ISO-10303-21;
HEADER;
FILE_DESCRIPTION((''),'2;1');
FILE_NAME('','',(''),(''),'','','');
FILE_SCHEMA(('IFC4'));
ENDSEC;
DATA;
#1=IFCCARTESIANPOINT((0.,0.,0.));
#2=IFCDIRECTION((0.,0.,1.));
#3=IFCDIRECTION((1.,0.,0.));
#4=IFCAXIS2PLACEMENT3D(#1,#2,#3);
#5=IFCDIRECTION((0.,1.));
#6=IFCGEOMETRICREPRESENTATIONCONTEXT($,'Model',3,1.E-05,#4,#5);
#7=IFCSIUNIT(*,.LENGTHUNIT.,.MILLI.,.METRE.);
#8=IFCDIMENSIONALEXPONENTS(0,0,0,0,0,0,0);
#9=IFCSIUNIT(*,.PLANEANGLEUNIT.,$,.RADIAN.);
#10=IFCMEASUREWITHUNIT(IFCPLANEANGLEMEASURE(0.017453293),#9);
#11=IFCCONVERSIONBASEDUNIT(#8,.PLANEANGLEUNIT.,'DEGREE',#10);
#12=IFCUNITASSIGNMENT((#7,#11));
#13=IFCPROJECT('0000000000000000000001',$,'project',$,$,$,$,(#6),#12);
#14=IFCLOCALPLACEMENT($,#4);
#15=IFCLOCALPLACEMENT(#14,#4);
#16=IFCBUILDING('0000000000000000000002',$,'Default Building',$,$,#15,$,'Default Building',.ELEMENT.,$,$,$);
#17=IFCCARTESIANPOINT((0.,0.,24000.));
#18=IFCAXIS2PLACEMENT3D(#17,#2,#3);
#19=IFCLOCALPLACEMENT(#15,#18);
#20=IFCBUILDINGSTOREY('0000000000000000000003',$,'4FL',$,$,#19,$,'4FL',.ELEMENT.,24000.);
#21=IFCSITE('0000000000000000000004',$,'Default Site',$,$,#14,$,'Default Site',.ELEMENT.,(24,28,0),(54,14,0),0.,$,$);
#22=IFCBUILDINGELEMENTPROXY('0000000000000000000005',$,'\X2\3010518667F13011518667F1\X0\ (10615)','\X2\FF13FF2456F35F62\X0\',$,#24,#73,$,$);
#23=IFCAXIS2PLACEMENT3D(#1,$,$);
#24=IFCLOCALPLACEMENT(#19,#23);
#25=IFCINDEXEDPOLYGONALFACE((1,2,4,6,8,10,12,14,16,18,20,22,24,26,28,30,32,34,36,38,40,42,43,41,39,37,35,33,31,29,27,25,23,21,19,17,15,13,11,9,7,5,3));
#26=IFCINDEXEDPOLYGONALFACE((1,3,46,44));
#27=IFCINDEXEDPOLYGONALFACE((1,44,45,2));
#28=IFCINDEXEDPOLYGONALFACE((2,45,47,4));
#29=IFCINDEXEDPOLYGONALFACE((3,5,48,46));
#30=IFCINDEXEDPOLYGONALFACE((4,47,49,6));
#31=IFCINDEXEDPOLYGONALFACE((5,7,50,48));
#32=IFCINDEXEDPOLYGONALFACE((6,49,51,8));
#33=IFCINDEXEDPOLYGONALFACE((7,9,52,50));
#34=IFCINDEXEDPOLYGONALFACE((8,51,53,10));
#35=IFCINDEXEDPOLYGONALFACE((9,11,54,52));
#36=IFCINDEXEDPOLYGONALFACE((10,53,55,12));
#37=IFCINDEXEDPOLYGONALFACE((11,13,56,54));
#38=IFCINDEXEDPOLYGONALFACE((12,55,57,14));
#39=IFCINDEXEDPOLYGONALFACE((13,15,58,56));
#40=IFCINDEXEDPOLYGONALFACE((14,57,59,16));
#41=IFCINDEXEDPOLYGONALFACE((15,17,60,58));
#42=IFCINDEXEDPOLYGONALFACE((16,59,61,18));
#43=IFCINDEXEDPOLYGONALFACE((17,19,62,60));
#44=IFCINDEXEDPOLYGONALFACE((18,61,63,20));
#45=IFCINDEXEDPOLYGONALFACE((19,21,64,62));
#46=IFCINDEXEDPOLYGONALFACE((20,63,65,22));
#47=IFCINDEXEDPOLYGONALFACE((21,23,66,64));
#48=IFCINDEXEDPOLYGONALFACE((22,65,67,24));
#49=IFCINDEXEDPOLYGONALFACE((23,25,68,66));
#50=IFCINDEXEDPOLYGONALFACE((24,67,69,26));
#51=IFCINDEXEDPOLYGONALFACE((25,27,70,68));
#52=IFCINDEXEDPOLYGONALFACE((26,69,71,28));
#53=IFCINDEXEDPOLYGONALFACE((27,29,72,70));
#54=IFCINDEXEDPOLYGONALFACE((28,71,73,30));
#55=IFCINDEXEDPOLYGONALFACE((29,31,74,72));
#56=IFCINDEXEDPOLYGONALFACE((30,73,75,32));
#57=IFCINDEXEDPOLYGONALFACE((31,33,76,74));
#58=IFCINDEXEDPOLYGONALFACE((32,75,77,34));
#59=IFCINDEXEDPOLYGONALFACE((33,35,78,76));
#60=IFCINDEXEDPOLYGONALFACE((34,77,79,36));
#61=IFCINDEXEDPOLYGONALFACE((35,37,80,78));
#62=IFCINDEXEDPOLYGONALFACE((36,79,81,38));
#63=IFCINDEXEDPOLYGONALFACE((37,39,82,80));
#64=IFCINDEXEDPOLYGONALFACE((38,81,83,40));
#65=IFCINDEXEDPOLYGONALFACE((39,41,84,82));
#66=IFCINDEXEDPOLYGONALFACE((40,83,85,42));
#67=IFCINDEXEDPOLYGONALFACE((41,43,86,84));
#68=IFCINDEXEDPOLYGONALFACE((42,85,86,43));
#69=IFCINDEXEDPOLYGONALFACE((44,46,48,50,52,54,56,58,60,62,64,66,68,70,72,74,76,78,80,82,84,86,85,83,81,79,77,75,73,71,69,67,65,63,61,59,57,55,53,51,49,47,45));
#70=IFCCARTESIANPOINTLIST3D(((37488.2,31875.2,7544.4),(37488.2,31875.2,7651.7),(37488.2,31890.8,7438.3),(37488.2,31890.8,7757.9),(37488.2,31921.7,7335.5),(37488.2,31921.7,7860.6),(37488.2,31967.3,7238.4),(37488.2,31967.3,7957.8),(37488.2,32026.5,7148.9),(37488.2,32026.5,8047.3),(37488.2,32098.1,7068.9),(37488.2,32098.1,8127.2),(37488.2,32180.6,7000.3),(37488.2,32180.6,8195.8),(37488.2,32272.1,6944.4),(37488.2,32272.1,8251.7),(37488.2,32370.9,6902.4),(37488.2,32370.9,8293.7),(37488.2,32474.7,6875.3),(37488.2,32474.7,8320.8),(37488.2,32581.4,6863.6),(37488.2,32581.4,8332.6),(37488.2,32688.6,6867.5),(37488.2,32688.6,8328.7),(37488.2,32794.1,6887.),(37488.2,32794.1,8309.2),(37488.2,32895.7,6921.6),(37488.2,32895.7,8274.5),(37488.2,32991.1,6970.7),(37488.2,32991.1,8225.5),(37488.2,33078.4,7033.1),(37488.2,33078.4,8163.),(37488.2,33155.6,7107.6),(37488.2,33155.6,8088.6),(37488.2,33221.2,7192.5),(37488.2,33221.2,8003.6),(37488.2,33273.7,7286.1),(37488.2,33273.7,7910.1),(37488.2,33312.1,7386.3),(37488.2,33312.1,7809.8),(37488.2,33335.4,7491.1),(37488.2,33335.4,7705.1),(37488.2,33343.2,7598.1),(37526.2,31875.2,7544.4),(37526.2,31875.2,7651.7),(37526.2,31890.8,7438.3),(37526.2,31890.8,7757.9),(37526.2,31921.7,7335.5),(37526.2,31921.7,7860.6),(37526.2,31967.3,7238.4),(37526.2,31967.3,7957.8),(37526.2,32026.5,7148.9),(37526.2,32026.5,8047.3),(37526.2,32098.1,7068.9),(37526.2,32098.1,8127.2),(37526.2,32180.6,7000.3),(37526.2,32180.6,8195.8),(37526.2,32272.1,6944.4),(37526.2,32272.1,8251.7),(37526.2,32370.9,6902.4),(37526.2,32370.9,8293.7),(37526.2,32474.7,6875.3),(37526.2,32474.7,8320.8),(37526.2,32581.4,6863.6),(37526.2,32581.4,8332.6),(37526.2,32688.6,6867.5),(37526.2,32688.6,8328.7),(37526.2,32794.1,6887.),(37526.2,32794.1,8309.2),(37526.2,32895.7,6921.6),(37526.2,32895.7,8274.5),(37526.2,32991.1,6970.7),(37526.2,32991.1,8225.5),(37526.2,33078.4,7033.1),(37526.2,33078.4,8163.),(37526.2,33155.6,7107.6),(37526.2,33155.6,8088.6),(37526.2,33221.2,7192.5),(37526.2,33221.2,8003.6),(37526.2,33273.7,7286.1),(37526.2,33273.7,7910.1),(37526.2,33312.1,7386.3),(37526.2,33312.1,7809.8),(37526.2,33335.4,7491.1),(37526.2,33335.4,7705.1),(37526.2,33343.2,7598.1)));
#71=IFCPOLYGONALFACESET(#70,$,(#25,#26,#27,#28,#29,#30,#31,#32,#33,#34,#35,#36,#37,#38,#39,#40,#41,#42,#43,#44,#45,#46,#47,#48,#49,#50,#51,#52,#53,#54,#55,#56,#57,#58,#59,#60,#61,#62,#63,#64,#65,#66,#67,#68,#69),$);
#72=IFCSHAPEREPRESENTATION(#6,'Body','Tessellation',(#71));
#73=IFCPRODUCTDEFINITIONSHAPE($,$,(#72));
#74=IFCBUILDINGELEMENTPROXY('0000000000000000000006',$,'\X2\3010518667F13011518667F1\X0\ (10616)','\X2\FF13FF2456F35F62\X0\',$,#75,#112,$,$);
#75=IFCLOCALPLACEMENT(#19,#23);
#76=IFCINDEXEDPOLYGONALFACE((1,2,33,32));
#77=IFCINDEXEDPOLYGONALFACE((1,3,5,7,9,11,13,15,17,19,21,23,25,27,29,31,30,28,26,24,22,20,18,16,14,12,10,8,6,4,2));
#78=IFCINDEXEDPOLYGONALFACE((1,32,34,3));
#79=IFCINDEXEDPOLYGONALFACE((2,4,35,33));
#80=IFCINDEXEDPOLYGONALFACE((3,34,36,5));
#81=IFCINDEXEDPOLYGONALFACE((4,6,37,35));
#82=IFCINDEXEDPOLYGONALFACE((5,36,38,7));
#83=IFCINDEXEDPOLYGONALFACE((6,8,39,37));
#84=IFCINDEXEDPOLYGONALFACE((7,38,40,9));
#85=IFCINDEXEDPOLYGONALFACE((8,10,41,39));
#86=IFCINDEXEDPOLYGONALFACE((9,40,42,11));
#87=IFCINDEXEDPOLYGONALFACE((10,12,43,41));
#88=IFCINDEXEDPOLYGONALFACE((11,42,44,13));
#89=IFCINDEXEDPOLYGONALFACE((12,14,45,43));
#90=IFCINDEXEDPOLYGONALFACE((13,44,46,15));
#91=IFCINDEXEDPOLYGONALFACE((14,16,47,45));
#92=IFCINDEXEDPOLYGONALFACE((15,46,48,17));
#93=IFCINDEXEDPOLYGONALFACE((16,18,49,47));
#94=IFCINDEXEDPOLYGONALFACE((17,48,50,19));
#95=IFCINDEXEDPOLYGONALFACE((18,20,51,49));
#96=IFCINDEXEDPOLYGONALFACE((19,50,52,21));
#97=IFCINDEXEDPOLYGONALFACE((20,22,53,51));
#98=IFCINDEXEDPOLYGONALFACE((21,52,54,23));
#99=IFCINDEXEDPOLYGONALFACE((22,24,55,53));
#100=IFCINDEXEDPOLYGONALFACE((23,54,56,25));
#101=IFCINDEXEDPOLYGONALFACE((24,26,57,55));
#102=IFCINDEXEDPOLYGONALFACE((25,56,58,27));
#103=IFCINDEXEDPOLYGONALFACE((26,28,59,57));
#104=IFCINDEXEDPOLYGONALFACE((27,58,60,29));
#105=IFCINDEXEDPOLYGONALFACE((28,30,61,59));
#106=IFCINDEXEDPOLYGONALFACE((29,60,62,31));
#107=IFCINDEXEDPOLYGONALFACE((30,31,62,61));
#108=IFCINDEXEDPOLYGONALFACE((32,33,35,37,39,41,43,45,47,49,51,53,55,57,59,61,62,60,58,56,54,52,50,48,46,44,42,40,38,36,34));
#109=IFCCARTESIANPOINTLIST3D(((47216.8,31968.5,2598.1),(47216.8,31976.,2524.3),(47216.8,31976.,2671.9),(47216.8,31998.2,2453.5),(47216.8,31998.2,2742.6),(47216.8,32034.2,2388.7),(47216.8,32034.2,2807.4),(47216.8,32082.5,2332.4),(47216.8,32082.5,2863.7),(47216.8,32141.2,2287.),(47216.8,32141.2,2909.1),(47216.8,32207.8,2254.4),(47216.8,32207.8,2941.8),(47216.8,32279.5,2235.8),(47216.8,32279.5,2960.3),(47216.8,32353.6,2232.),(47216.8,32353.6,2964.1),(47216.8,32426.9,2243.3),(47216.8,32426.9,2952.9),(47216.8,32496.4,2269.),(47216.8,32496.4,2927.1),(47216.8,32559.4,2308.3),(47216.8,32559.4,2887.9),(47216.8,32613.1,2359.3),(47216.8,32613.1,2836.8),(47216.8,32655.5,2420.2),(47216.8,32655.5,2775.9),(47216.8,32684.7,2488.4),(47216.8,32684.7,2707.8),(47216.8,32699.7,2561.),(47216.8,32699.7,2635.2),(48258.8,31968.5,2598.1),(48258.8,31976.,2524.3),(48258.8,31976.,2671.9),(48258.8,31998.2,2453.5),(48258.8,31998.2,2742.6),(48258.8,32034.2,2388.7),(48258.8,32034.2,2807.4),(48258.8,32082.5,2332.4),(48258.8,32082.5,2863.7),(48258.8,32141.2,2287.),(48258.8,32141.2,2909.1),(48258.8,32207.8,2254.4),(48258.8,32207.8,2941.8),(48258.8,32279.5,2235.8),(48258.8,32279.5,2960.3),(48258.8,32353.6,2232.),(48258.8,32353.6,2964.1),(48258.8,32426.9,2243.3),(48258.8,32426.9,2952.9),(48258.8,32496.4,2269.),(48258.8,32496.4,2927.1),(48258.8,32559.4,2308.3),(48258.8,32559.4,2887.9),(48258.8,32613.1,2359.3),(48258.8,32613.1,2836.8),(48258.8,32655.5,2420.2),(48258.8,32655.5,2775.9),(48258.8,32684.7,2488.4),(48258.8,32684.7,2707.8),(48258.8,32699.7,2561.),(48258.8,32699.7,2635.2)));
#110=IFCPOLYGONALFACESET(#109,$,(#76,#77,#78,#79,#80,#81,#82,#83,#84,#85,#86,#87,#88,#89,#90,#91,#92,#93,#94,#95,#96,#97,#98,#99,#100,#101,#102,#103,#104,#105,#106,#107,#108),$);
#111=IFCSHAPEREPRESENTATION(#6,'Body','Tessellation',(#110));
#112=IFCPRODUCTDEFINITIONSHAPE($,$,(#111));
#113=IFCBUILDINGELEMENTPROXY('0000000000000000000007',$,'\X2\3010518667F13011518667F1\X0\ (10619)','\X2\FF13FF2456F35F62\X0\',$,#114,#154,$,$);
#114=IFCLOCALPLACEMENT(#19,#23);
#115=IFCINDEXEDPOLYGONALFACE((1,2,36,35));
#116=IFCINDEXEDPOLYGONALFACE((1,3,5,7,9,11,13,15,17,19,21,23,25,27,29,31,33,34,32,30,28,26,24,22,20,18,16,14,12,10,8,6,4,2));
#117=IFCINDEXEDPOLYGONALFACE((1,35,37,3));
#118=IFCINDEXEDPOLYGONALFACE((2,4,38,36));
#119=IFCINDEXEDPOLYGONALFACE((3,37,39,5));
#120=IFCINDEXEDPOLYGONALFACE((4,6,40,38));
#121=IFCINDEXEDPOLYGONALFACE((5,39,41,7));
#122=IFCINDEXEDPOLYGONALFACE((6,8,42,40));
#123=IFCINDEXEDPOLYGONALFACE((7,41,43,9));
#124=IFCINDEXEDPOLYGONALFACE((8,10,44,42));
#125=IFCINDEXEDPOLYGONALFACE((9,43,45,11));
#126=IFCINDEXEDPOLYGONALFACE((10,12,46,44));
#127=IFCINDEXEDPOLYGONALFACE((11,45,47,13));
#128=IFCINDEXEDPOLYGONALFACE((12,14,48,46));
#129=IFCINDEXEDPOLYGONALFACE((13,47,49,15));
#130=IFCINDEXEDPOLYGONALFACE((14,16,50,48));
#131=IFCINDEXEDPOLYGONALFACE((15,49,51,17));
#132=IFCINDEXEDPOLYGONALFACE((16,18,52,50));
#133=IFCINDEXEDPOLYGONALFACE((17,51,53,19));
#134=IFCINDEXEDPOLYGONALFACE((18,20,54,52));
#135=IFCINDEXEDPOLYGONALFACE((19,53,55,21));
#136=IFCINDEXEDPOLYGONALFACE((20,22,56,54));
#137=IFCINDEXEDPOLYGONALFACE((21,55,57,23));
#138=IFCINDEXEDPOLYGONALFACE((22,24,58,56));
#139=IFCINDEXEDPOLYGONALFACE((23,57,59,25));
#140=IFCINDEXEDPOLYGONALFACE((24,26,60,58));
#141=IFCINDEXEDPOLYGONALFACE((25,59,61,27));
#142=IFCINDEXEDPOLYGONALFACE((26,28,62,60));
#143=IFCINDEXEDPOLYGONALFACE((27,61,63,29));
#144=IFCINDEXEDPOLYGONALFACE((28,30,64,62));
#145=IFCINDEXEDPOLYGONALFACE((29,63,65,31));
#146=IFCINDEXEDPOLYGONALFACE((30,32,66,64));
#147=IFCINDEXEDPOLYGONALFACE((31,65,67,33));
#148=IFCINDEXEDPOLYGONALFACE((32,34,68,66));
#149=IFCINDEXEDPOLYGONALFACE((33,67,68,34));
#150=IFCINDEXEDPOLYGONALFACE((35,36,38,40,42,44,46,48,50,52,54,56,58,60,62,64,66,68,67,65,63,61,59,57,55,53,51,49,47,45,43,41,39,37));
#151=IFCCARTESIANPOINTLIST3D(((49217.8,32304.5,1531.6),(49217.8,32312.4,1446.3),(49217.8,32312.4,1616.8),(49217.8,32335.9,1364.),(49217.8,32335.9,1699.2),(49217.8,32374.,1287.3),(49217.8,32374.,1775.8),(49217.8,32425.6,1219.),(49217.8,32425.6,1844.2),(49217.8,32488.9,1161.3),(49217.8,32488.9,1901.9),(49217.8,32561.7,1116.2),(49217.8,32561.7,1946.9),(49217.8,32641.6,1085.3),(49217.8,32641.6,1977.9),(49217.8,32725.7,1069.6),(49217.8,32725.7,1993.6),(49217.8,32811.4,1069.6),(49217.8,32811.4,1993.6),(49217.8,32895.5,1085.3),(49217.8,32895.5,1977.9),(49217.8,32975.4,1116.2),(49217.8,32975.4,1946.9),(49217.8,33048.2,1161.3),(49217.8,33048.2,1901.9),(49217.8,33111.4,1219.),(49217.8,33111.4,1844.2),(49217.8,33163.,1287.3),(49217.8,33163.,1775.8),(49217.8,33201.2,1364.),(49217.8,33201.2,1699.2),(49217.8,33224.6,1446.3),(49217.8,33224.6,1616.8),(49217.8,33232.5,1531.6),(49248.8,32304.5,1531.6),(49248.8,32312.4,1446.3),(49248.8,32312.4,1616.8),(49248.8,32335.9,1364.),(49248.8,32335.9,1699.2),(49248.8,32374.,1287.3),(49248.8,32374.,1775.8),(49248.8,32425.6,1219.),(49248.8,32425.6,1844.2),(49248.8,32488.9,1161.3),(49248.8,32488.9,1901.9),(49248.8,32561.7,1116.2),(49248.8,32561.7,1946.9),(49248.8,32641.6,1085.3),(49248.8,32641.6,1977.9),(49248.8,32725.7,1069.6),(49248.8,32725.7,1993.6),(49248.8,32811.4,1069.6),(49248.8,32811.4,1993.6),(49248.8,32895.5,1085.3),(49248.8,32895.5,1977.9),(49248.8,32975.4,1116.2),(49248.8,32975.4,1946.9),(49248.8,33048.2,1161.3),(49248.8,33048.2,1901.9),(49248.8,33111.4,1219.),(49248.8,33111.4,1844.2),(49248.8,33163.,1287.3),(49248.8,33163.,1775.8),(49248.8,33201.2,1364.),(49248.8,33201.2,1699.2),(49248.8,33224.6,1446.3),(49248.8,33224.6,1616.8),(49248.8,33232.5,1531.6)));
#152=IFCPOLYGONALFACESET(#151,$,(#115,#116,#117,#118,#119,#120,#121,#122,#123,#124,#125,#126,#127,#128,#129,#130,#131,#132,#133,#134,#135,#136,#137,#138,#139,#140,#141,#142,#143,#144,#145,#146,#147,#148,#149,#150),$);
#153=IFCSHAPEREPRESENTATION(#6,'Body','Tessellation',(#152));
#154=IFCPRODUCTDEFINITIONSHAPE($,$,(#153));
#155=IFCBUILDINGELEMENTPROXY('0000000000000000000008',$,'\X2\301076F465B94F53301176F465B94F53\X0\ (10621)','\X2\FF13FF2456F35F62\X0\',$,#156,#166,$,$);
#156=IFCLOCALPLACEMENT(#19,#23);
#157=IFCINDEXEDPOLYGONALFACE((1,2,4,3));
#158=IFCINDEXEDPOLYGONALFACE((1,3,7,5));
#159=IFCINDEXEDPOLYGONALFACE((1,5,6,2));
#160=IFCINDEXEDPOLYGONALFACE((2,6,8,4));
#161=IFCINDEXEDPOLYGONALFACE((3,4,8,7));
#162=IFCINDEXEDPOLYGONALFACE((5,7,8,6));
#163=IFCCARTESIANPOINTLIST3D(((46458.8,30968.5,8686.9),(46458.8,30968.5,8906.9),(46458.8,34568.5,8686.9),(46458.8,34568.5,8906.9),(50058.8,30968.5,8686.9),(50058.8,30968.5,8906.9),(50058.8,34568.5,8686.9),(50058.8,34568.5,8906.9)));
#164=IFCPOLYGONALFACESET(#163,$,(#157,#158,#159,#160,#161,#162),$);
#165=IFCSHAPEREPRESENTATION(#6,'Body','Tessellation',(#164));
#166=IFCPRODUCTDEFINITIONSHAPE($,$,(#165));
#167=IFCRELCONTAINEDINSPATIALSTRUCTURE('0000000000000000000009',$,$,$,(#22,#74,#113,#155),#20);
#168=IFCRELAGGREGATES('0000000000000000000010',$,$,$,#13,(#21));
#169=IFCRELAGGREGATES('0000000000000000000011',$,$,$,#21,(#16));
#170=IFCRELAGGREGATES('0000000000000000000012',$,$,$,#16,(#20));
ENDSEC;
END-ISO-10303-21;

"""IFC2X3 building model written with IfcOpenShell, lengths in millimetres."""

from ifc_helpers import new_model, entity, si_unit, converted_unit, direction, frame, origin_with_axes, origin_2d_with_axis, place, context, project, spatial, rectangle, circle, extrude, source, transform, mapped, element, save


model = new_model("IFC2X3")

# Units and contexts
model_context = context("Model", 3, precision=1e-05, world=origin_with_axes(), true_north=direction((0.0, 1.0)))
ifc_project = project(units=[si_unit("LENGTHUNIT", "METRE", prefix="MILLI"), converted_unit("PLANEANGLEUNIT", "DEGREE", entity("IfcPlaneAngleMeasure", 0.017453293), si_unit("PLANEANGLEUNIT", "RADIAN"), dimensions=[0, 0, 0, 0, 0, 0, 0])], contexts=[model_context])

# Site, building, storey
site_placement = place(None, origin_with_axes())
site = spatial("IfcSite", under=ifc_project, at=site_placement, Name="Default Site", LongName="Default Site", CompositionType="ELEMENT", RefLatitude=(24, 28, 0), RefLongitude=(54, 14, 0), RefElevation=0.0)
building_placement = place(site_placement, origin_with_axes())
building = spatial("IfcBuilding", under=site, at=building_placement, Name="Default Building", LongName="Default Building", CompositionType="ELEMENT")
storey_placement = place(building_placement, frame((0.0, 0.0, 24000.0), z_axis=(0.0, 0.0, 1.0), x_axis=(1.0, 0.0, 0.0)))
storey = spatial("IfcBuildingStorey", under=building, at=storey_placement, Name="4FL", LongName="4FL", CompositionType="ELEMENT", Elevation=24000.0)

# Building element proxies
shared_shape_1 = source(origin_with_axes(), model_context, "Body", "SweptSolid", [
    extrude(circle(Radius=735.0, at=origin_2d_with_axis()), frame((0.0, 0.0, 0.0), z_axis=(0.0, 0.0, 1.0), x_axis=(1.0, 0.0, 0.0)), (0.0, 0.0, 1.0), 38.0),
])
proxy_1_placement = place(storey_placement, frame((37488.2, 32608.2, 7598.1), z_axis=(1.0, 0.0, 0.0), x_axis=(0.0, 1.0, 0.0)))
element("IfcBuildingElementProxy", 1, at=proxy_1_placement, inside=storey, Name="【円柱】円柱 (10615)", Description="３Ｄ図形", context=model_context, shape_type="MappedRepresentation", body=[
    mapped(shared_shape_1, transform((0.0, 0.0, 0.0))),
])
shared_shape_2 = source(origin_with_axes(), model_context, "Body", "SweptSolid", [
    extrude(circle(Radius=366.5, at=origin_2d_with_axis()), frame((0.0, 0.0, 0.0), z_axis=(0.0, 0.0, 1.0), x_axis=(1.0, 0.0, 0.0)), (0.0, 0.0, 1.0), 1042.0),
])
proxy_2_placement = place(storey_placement, frame((48258.8, 32335.0, 2598.1), z_axis=(-1.0, 0.0, 0.0), x_axis=(0.0, -1.0, 0.0)))
element("IfcBuildingElementProxy", 2, at=proxy_2_placement, inside=storey, Name="【円柱】円柱 (10616)", Description="３Ｄ図形", context=model_context, shape_type="MappedRepresentation", body=[
    mapped(shared_shape_2, transform((0.0, 0.0, 0.0))),
])
shared_shape_3 = source(origin_with_axes(), model_context, "Body", "SweptSolid", [
    extrude(circle(Radius=464.0, at=origin_2d_with_axis()), frame((0.0, 0.0, 0.0), z_axis=(0.0, 0.0, 1.0), x_axis=(1.0, 0.0, 0.0)), (0.0, 0.0, 1.0), 31.0),
])
proxy_3_placement = place(storey_placement, frame((49217.8, 32768.5, 1531.6), z_axis=(1.0, 0.0, 0.0), x_axis=(0.0, -1.0, 0.0)))
element("IfcBuildingElementProxy", 3, at=proxy_3_placement, inside=storey, Name="【円柱】円柱 (10619)", Description="３Ｄ図形", context=model_context, shape_type="MappedRepresentation", body=[
    mapped(shared_shape_3, transform((0.0, 0.0, 0.0))),
])
shared_shape_4 = source(origin_with_axes(), model_context, "Body", "SweptSolid", [
    extrude(rectangle(XDim=3600.0, YDim=220.0, at=origin_2d_with_axis()), frame((0.0, 0.0, 0.0), z_axis=(0.0, 0.0, 1.0), x_axis=(1.0, 0.0, 0.0)), (0.0, 0.0, 1.0), 3600.0),
])
proxy_4_placement = place(storey_placement, frame((48258.8, 34568.5, 8796.9), z_axis=(0.0, -1.0, 0.0), x_axis=(1.0, 0.0, 0.0)))
element("IfcBuildingElementProxy", 4, at=proxy_4_placement, inside=storey, Name="【直方体】直方体 (10621)", Description="３Ｄ図形", context=model_context, shape_type="MappedRepresentation", body=[
    mapped(shared_shape_4, transform((0.0, 0.0, 0.0))),
])

save(model, "model.ifc")
